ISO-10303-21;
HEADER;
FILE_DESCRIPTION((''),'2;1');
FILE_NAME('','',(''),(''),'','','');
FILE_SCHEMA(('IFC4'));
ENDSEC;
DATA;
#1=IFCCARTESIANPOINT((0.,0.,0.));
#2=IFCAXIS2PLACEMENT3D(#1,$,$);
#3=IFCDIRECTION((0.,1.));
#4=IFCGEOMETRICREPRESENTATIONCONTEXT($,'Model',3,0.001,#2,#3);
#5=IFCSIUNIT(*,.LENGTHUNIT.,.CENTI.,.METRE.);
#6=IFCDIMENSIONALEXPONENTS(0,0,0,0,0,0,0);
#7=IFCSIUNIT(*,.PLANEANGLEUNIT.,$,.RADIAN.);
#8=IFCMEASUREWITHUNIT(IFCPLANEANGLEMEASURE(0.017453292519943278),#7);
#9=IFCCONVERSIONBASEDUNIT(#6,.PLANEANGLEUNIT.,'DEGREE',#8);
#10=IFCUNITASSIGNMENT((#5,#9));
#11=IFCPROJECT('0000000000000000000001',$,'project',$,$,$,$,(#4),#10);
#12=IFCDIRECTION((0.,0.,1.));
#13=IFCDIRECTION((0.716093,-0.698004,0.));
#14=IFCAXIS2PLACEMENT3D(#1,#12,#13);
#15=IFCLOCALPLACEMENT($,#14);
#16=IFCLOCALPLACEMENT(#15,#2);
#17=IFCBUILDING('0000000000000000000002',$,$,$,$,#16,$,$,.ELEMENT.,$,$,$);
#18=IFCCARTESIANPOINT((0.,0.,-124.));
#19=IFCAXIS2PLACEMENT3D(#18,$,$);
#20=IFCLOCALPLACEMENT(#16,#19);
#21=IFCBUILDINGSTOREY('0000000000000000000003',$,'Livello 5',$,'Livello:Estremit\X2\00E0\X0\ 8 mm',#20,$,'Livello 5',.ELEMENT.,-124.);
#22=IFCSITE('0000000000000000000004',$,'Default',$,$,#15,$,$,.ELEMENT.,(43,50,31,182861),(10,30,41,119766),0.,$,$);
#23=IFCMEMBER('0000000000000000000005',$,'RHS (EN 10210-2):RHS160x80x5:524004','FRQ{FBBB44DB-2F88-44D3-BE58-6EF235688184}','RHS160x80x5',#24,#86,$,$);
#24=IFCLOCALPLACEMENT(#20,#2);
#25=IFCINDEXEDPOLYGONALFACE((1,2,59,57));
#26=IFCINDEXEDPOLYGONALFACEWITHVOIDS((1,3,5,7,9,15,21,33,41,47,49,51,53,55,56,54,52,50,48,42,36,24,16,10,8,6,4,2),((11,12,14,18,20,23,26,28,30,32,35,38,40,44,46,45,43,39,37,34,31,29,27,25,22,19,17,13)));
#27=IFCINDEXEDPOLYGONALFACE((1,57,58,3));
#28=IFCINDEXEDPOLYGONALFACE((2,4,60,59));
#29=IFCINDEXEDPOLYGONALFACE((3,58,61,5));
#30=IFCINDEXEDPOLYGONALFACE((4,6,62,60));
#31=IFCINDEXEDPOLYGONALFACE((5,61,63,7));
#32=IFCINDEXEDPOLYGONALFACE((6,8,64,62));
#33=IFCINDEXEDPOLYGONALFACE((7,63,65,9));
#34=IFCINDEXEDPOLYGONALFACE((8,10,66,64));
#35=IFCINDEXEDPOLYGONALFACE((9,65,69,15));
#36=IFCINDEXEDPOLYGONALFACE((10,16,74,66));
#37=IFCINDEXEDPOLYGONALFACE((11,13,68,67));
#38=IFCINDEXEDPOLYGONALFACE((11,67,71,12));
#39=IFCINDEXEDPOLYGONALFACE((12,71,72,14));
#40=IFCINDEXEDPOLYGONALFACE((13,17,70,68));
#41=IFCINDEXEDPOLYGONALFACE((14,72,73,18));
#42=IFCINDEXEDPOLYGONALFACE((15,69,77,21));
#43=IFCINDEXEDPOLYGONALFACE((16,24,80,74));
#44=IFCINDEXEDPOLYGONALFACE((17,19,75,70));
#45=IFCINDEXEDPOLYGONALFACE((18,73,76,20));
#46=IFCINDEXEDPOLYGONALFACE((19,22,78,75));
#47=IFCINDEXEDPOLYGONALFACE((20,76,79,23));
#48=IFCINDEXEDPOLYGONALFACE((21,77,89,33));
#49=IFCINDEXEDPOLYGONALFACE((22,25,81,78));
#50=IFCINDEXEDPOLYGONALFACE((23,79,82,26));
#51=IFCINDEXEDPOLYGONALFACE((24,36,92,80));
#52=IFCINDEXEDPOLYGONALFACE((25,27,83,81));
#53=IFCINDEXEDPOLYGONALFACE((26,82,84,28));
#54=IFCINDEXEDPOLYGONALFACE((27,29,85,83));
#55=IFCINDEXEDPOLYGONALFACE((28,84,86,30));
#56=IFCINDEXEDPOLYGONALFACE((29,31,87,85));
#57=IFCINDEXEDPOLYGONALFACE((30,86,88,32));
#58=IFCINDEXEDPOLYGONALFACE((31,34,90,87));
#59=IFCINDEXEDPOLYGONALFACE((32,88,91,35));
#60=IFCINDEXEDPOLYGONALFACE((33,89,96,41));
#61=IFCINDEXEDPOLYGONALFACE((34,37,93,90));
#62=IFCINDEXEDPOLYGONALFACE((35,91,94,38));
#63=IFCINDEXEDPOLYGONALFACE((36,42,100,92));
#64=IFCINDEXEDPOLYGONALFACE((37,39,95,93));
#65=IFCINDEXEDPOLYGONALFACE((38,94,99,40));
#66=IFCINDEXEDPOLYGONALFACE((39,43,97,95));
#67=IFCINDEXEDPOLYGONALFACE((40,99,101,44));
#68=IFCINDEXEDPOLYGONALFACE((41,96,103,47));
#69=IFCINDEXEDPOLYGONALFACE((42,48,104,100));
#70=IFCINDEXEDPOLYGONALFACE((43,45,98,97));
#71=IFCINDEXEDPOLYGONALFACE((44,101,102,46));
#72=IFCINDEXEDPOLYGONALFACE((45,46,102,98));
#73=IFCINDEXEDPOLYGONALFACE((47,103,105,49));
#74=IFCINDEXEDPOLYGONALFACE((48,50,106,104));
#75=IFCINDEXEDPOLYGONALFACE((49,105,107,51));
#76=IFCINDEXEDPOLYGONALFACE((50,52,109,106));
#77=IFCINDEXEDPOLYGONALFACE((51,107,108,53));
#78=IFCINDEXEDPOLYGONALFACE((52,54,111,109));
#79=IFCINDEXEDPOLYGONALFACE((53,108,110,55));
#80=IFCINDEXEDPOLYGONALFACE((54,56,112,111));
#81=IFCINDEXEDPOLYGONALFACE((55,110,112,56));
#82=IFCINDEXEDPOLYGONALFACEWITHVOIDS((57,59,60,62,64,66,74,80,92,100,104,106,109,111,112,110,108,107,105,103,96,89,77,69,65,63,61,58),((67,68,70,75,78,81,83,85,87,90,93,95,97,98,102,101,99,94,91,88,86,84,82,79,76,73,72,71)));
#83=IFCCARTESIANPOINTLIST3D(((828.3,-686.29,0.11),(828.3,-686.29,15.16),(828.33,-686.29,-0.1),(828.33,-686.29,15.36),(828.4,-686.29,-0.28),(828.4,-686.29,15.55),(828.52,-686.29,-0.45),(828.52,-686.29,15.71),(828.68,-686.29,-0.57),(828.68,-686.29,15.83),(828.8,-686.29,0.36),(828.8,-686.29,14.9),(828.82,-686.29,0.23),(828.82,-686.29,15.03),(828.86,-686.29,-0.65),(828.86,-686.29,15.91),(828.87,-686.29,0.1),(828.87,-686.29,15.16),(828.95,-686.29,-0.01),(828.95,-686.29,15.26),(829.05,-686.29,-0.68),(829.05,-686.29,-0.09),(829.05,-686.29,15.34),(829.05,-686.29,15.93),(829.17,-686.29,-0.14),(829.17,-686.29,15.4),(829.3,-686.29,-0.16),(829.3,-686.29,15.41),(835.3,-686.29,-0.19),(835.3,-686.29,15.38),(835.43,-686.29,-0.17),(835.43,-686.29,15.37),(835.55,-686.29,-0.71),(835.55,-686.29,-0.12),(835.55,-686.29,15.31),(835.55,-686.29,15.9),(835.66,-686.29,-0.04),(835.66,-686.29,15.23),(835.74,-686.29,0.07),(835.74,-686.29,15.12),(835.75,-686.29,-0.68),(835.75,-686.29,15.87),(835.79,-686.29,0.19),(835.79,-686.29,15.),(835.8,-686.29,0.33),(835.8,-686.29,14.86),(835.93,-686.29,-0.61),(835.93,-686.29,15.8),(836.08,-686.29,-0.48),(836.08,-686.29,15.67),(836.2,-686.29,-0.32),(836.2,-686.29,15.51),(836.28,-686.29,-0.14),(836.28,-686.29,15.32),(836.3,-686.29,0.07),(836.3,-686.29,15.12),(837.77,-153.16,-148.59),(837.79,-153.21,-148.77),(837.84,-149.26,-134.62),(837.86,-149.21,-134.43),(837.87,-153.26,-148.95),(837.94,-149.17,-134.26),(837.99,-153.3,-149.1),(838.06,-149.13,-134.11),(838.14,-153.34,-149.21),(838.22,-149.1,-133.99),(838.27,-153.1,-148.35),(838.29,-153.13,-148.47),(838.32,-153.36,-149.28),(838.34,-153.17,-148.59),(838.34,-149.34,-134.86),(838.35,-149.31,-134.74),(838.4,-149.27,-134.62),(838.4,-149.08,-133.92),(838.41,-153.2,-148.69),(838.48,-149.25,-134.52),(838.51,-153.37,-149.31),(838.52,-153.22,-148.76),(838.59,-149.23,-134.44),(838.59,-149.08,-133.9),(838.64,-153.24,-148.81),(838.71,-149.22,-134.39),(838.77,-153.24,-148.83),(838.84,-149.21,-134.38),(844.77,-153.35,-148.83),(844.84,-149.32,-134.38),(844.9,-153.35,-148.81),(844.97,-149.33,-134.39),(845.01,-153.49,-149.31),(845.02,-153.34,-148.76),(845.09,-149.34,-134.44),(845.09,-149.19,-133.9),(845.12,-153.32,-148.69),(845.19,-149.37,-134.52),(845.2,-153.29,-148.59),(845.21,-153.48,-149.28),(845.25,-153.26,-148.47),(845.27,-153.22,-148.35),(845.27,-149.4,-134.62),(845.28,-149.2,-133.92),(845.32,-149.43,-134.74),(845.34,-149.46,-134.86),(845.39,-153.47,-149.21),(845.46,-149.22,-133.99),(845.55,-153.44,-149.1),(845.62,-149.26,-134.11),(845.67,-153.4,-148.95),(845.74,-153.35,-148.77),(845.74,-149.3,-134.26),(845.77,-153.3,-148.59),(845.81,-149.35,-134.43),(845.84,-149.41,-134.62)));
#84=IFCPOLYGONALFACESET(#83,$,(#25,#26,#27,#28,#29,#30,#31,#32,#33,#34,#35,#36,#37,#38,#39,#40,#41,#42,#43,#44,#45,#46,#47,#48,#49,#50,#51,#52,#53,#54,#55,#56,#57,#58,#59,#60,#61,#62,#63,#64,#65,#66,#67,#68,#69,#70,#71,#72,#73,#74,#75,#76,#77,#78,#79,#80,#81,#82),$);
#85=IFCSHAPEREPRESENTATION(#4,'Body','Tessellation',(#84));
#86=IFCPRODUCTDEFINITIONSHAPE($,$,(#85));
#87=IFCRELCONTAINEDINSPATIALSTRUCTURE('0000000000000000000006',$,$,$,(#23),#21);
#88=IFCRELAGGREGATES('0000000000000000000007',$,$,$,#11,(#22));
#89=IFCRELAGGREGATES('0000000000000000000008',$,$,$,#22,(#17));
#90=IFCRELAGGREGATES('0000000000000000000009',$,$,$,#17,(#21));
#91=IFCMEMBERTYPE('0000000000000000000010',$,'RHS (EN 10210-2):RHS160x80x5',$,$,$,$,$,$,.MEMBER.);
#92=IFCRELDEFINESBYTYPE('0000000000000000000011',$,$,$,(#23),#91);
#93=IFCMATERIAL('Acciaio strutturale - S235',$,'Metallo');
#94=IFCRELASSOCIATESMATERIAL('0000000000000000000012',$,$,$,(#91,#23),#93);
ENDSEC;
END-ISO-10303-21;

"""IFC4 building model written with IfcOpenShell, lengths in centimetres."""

from ifc_helpers import new_model, entity, si_unit, converted_unit, direction, frame, origin, origin_2d, place, context, project, spatial, hollow_rectangle, extrude, clip, halfspace, material, type_object, element, save


model = new_model("IFC4")

# Units and contexts
model_context = context("Model", 3, precision=0.001, world=origin(), true_north=direction((0.0, 1.0)))
ifc_project = project(units=[si_unit("LENGTHUNIT", "METRE", prefix="CENTI"), converted_unit("PLANEANGLEUNIT", "DEGREE", entity("IfcPlaneAngleMeasure", 0.017453292519943278), si_unit("PLANEANGLEUNIT", "RADIAN"), dimensions=[0, 0, 0, 0, 0, 0, 0])], contexts=[model_context])

# Site, building, storey
site_placement = place(None, frame((0.0, 0.0, 0.0), z_axis=(0.0, 0.0, 1.0), x_axis=(0.716093, -0.698004, 0.0)))
site = spatial("IfcSite", under=ifc_project, at=site_placement, Name="Default", CompositionType="ELEMENT", RefLatitude=(43, 50, 31, 182861), RefLongitude=(10, 30, 41, 119766), RefElevation=0.0)
building_placement = place(site_placement, origin())
building = spatial("IfcBuilding", under=site, at=building_placement, CompositionType="ELEMENT")
storey_placement = place(building_placement, frame((0.0, 0.0, -124.0)))
storey = spatial("IfcBuildingStorey", under=building, at=storey_placement, Name="Livello 5", ObjectType="Livello:Estremità 8 mm", LongName="Livello 5", CompositionType="ELEMENT", Elevation=-124.0)

# Member
ifc_material_1 = material(Name="Acciaio strutturale - S235", Category="Metallo")
member_type_1 = type_object("IfcMemberType", Name="RHS (EN 10210-2):RHS160x80x5", PredefinedType="MEMBER", material=ifc_material_1)
member_1_placement = place(storey_placement, frame((831.79, -715.15, 15.66), z_axis=(-0.0171, -0.963097, 0.268612), x_axis=(0.999842, -0.017752, 0.0)))
element("IfcMember", 1, at=member_1_placement, inside=storey, type_object=member_type_1, material=ifc_material_1, Name="RHS (EN 10210-2):RHS160x80x5:524004", Description="FRQ{FBBB44DB-2F88-44D3-BE58-6EF235688184}", ObjectType="RHS160x80x5", context=model_context, shape_type="Clipping", body=[
    clip(extrude(hollow_rectangle(XDim=8.0, YDim=16.0, WallThickness=0.5, InnerFilletRadius=0.5, OuterFilletRadius=0.75, at=origin_2d()), origin(), (0.0, 0.0, -1.0), 585.48), halfspace(frame((-832.17, 108.14, 15.52), z_axis=(-0.017752, 0.26857, -0.963097), x_axis=(-0.999842, -0.004768, 0.0171)), True)),
])

save(model, "model.ifc")
